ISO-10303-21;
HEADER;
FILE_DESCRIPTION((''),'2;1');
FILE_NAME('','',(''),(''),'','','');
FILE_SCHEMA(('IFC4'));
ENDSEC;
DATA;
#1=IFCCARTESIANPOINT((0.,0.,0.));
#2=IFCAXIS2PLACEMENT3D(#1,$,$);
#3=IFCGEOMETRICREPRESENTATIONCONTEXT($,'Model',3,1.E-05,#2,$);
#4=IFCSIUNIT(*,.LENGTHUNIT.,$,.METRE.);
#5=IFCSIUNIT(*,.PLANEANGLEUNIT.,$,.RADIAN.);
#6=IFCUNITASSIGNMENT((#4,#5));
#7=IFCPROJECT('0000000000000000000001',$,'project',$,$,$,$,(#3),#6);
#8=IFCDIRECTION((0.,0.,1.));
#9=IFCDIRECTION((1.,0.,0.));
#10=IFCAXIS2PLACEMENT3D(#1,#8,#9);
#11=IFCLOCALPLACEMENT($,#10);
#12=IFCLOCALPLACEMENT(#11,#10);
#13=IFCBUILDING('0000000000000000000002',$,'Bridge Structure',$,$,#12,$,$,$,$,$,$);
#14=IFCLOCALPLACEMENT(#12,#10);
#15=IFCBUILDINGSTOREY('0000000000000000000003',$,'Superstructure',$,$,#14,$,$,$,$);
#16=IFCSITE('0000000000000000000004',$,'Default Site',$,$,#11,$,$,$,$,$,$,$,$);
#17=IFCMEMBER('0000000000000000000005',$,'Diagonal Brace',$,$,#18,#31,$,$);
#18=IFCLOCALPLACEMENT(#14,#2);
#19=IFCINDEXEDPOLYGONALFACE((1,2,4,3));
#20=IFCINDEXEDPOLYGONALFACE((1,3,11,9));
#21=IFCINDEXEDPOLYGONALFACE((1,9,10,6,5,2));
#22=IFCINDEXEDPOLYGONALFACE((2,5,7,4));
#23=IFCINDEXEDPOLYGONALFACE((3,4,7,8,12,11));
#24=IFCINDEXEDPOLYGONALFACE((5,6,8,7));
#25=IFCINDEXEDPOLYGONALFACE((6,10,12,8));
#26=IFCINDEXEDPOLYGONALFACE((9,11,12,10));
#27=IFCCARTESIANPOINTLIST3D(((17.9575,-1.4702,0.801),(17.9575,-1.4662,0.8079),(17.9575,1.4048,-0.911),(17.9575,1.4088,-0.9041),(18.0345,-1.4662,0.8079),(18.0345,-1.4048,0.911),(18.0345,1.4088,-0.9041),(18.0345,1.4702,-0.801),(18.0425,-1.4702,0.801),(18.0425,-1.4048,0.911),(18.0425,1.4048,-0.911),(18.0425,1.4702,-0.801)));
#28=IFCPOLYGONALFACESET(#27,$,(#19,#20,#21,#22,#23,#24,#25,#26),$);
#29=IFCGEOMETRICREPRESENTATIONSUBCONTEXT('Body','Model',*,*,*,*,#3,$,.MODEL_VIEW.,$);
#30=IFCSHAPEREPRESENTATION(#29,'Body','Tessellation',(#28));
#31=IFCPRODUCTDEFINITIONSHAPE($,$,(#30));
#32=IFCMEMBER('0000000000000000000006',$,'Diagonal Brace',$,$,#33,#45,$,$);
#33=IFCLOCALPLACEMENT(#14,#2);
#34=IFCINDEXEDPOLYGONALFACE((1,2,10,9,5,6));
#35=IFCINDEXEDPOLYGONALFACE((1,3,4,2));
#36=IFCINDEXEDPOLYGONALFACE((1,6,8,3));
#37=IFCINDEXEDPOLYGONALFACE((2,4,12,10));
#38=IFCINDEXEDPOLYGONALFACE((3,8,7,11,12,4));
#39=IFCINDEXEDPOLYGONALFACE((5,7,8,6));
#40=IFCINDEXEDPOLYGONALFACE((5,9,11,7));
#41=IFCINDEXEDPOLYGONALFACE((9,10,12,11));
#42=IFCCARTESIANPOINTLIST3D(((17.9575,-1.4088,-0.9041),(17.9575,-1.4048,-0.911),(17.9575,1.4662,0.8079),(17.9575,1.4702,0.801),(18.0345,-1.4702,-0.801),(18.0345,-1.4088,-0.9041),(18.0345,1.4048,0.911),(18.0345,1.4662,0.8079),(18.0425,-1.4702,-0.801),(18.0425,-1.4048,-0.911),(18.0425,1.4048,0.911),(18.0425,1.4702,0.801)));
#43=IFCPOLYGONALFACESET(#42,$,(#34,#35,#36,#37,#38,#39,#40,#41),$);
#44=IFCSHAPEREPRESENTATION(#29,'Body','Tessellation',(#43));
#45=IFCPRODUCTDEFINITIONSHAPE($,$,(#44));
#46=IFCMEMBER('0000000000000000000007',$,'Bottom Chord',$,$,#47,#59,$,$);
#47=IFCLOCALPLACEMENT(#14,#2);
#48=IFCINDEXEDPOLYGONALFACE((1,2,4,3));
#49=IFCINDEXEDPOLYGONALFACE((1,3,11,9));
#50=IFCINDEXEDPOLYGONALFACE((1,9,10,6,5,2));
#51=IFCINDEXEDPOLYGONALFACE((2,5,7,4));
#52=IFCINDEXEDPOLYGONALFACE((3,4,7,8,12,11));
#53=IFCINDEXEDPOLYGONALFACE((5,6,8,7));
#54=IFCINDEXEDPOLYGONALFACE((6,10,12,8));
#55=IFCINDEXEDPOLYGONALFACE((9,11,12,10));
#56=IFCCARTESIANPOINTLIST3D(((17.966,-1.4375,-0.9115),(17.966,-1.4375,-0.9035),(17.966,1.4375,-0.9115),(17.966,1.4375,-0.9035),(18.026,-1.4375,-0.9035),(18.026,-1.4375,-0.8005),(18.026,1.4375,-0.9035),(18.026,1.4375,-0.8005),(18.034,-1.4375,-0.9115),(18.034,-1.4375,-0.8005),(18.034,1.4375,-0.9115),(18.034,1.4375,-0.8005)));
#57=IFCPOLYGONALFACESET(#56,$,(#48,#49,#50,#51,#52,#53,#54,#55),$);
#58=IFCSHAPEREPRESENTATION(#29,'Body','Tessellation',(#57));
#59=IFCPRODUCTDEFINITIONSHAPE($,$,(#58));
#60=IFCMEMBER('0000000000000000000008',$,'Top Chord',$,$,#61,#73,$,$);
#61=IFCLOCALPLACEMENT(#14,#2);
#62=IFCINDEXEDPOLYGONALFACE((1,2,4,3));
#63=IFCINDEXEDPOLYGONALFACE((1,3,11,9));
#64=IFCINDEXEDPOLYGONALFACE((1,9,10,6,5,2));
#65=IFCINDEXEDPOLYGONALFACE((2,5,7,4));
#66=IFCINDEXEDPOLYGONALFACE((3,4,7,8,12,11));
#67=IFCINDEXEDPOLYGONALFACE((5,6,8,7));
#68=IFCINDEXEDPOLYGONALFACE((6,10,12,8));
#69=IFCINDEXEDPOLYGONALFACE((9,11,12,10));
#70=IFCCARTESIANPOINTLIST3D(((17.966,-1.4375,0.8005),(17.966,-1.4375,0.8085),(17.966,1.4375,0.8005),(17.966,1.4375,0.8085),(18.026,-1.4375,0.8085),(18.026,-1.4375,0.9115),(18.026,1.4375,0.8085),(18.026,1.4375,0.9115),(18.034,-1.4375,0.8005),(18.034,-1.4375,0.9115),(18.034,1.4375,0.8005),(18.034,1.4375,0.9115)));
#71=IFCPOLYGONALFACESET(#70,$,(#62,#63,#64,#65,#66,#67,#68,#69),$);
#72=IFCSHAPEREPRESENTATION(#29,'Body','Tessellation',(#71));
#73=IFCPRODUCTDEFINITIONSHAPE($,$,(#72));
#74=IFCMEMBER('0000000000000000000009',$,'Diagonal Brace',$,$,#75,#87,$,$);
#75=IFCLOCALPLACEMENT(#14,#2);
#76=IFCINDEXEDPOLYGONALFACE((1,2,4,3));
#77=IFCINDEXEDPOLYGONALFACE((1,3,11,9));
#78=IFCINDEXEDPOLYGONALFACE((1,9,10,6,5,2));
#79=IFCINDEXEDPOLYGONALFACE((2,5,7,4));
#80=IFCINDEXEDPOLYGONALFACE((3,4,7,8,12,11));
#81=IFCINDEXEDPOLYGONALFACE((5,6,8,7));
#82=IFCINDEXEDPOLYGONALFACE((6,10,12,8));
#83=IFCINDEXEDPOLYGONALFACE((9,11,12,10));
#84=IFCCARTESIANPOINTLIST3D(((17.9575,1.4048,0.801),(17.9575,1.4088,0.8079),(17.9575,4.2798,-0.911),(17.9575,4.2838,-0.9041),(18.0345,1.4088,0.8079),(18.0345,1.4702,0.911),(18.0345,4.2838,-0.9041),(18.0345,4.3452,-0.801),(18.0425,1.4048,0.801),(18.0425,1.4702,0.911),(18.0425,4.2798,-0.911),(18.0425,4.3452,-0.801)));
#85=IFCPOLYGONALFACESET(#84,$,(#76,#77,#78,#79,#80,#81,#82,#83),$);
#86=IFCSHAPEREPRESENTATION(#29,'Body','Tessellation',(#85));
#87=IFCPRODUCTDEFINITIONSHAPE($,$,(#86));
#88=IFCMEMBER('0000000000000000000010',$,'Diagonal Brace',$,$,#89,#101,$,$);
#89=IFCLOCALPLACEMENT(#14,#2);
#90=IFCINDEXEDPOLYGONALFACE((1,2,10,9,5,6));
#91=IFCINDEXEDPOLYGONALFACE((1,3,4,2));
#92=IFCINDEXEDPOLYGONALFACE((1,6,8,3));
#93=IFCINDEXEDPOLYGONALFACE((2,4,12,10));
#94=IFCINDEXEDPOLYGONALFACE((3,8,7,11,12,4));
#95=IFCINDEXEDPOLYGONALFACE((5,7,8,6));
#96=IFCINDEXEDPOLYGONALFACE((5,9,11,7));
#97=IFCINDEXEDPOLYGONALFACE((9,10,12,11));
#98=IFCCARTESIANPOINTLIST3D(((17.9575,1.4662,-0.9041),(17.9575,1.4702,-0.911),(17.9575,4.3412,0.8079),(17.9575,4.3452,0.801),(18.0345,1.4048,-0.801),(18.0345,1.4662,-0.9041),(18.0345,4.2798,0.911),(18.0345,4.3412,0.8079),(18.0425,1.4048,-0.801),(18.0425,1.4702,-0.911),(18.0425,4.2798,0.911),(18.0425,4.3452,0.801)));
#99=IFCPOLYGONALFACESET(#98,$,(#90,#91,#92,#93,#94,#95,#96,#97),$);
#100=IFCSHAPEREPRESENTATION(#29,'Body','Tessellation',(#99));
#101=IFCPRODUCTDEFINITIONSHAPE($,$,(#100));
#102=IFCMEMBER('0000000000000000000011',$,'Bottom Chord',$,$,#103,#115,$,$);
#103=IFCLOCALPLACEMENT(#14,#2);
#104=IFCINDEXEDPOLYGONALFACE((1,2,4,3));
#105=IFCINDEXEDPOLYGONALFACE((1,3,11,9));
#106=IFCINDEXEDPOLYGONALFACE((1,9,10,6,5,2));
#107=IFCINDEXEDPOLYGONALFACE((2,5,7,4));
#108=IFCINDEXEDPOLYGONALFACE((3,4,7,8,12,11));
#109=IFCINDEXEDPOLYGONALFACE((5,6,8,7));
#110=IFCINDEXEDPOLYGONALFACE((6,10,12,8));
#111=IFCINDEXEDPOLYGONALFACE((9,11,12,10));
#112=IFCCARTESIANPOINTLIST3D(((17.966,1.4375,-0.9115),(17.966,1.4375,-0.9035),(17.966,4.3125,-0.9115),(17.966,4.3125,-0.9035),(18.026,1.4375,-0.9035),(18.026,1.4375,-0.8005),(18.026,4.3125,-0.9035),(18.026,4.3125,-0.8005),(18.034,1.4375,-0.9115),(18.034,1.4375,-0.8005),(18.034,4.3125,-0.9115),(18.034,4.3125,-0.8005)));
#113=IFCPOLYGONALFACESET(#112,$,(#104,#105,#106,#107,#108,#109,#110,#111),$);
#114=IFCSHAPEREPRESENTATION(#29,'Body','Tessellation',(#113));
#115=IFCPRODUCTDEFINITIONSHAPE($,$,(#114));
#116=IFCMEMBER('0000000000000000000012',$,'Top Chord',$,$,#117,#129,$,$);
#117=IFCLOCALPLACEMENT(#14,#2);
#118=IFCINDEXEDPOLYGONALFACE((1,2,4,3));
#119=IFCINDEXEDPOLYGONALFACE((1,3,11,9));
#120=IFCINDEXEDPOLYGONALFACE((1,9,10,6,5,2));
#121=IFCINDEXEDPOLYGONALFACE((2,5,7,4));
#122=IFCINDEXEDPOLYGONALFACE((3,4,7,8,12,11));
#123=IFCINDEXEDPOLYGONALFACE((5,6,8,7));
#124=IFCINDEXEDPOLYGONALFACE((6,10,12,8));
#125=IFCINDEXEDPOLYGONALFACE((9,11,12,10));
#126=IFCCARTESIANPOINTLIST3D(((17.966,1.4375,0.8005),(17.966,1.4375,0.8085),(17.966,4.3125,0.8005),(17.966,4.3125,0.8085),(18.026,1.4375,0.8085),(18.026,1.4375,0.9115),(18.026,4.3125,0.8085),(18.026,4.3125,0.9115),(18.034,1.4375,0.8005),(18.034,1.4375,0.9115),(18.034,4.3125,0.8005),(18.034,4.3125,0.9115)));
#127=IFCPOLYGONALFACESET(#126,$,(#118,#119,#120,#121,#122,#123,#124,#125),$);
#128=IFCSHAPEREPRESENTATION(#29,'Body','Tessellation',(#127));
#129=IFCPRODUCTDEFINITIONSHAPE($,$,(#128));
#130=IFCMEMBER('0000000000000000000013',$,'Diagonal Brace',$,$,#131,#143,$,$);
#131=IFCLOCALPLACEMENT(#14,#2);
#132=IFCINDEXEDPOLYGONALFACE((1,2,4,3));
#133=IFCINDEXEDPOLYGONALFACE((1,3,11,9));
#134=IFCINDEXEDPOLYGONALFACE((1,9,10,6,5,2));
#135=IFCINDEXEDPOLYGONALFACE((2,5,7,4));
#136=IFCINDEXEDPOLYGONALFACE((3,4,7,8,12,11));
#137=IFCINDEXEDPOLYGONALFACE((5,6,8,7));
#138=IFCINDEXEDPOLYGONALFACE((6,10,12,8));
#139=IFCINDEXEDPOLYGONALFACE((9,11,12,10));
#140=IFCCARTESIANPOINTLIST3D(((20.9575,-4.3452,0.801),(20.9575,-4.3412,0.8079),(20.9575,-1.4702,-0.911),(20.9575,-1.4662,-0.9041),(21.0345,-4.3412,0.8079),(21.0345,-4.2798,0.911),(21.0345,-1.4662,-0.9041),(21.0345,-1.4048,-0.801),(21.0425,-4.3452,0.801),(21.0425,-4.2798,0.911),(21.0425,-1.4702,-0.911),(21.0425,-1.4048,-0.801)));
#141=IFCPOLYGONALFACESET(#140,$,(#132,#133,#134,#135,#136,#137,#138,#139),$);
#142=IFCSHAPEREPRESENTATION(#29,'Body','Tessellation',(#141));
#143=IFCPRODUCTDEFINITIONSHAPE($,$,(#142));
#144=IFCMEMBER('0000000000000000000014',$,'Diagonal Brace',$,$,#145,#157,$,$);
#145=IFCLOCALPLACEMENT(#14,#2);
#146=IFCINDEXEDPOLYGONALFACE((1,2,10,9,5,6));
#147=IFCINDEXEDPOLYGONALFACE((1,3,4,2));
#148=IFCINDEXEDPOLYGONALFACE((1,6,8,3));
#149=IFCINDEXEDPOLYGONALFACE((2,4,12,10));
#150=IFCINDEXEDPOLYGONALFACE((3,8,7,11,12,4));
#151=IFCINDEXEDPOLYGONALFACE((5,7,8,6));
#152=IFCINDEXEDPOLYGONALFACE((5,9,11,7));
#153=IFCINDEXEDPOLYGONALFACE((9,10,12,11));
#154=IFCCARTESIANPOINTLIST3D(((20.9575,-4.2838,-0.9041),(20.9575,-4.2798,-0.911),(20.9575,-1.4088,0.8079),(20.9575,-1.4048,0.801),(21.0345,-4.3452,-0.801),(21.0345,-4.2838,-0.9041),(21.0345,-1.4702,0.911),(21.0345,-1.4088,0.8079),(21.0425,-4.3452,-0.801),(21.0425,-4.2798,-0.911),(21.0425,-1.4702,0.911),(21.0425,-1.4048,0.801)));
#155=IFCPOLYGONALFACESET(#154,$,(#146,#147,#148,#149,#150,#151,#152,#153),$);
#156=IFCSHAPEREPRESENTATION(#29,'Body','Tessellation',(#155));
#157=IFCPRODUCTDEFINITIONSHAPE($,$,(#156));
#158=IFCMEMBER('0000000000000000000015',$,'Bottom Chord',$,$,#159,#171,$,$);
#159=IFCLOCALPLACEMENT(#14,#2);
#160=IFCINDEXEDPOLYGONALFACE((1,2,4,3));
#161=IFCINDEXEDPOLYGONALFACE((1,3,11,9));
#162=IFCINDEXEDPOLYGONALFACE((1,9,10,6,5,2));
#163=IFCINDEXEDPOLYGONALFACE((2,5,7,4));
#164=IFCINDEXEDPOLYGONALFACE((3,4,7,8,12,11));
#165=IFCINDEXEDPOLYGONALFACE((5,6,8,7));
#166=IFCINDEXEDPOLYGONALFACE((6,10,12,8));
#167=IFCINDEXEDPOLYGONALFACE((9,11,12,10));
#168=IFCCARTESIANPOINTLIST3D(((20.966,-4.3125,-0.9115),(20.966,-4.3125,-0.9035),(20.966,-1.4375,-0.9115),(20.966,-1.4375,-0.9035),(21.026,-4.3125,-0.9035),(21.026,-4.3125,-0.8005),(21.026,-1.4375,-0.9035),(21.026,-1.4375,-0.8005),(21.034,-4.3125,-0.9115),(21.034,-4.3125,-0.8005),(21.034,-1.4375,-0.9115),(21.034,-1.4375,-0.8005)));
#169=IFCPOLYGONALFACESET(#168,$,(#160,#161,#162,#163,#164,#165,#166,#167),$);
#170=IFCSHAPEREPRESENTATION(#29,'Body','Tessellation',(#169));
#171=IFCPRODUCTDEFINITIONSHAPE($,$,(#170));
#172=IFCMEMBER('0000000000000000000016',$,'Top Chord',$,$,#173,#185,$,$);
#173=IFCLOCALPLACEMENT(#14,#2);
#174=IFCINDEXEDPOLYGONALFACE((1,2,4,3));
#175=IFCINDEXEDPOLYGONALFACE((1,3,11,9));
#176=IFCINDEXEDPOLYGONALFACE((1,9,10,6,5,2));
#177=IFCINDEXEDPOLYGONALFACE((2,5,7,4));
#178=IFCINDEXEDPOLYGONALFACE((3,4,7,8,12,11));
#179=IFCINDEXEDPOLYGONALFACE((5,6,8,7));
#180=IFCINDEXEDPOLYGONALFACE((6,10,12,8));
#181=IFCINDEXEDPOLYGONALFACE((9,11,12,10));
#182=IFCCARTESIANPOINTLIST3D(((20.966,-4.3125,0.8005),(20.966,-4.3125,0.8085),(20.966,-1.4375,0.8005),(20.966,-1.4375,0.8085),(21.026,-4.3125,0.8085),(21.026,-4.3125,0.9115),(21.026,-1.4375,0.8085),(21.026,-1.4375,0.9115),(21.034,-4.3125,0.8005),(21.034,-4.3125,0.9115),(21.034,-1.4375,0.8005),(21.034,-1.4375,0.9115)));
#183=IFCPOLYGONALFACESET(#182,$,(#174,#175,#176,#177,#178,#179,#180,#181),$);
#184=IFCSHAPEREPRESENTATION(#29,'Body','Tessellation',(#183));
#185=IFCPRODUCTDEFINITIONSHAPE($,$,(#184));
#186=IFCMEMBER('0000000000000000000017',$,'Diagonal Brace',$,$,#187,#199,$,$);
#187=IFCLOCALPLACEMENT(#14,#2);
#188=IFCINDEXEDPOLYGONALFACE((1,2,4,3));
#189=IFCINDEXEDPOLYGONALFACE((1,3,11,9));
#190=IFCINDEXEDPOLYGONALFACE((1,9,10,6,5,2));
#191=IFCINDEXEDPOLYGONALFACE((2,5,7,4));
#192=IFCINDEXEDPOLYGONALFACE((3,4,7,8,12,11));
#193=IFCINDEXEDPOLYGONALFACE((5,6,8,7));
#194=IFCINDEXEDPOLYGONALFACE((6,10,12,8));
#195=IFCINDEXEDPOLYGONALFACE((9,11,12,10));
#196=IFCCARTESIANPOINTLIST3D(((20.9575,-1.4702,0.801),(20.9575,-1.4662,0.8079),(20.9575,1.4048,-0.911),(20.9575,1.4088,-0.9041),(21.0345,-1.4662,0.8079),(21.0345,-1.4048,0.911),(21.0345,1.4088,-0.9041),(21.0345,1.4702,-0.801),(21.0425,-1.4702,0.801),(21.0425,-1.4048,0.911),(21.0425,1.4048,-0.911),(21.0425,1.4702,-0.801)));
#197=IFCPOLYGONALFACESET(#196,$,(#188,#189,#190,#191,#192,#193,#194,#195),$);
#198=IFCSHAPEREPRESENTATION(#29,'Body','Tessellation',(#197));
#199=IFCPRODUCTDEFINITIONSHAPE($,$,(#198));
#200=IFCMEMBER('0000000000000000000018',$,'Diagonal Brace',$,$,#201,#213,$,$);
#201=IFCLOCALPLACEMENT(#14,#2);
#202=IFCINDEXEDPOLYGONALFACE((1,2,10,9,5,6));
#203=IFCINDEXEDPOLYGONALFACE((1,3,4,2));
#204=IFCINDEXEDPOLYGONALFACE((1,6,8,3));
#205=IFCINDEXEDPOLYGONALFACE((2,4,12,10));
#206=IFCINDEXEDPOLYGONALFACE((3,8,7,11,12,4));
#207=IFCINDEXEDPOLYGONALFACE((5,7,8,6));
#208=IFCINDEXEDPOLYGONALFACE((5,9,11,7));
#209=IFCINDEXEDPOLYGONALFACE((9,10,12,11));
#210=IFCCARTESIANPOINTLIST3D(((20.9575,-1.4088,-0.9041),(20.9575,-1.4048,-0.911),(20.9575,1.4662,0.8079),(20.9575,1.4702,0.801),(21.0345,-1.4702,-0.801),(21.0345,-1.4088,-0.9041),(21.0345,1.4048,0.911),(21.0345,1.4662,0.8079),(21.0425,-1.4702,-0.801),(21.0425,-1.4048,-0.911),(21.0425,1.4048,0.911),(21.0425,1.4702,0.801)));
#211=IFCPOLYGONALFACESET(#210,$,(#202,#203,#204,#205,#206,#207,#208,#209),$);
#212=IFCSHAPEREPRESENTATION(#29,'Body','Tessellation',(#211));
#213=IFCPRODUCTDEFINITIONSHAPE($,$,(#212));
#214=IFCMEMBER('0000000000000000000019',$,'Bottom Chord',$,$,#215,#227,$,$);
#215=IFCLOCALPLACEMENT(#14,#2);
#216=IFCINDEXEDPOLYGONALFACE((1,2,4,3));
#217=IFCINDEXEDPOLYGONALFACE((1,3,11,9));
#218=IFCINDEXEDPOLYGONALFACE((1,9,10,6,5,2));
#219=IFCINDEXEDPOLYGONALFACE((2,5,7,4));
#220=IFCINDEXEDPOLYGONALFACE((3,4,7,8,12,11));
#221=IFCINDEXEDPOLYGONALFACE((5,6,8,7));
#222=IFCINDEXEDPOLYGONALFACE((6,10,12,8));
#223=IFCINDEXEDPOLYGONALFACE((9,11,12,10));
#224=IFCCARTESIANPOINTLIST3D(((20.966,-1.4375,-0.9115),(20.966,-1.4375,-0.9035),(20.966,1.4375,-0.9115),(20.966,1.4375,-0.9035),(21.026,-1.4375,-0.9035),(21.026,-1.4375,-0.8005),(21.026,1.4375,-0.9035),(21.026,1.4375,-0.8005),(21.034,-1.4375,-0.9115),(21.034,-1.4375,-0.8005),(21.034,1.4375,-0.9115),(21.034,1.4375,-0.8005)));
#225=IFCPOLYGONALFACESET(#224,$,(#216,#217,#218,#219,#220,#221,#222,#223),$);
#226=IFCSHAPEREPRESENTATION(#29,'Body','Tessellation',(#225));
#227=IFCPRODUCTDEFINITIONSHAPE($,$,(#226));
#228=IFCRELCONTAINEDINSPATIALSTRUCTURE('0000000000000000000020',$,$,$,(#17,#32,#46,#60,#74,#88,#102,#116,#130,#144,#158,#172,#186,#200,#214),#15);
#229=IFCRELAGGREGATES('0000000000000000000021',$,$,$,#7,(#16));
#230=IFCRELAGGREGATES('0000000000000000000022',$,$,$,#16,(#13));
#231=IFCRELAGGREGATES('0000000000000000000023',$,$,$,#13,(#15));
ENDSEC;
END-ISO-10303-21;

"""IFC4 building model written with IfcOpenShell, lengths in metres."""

from ifc_helpers import new_model, si_unit, frame, origin, origin_with_axes, origin_2d_with_axis, place, context, subcontext, project, spatial, l_section, extrude, element, save


model = new_model("IFC4")

# Units and contexts
model_context = context("Model", 3, precision=1e-05, world=origin())
body_context = subcontext(model_context, "Body", "Model", "MODEL_VIEW")
ifc_project = project(units=[si_unit("LENGTHUNIT", "METRE"), si_unit("PLANEANGLEUNIT", "RADIAN")], contexts=[model_context])

# Site, building, storey
site_placement = place(None, origin_with_axes())
site = spatial("IfcSite", under=ifc_project, at=site_placement, Name="Default Site")
building_placement = place(site_placement, origin_with_axes())
building = spatial("IfcBuilding", under=site, at=building_placement, Name="Bridge Structure")
storey_placement = place(building_placement, origin_with_axes())
storey = spatial("IfcBuildingStorey", under=building, at=storey_placement, Name="Superstructure")

# Members
for number, where, z_axis, x_axis, name in (
    (1, (18.0, -1.4375, 0.856), (0.0, 0.859202, -0.511636), (-1.0, 0.0, 0.0), "Diagonal Brace"),
    (2, (18.0, -1.4375, -0.856), (0.0, 0.859202, 0.511636), (-1.0, 0.0, 0.0), "Diagonal Brace"),
):
    element("IfcMember", number, at=place(storey_placement, frame(where, z_axis=z_axis, x_axis=x_axis)), inside=storey, Name=name, context=body_context, shape_type="SweptSolid", body=[
        extrude(l_section(Depth=0.128, Width=0.085, Thickness=0.008, at=origin_2d_with_axis()), origin_with_axes(), (0.0, 0.0, 1.0), 3.3461),
    ])
for number, where, z_axis, x_axis, name in (
    (3, (18.0, -1.4375, -0.856), (0.0, 1.0, 0.0), (-1.0, 0.0, 0.0), "Bottom Chord"),
    (4, (18.0, -1.4375, 0.856), (0.0, 1.0, 0.0), (-1.0, 0.0, 0.0), "Top Chord"),
):
    element("IfcMember", number, at=place(storey_placement, frame(where, z_axis=z_axis, x_axis=x_axis)), inside=storey, Name=name, context=body_context, shape_type="SweptSolid", body=[
        extrude(l_section(Depth=0.111, Width=0.068, Thickness=0.008, at=origin_2d_with_axis()), origin_with_axes(), (0.0, 0.0, 1.0), 2.875),
    ])
for number, where, z_axis, x_axis, name in (
    (5, (18.0, 1.4375, 0.856), (0.0, 0.859202, -0.511636), (-1.0, 0.0, 0.0), "Diagonal Brace"),
    (6, (18.0, 1.4375, -0.856), (0.0, 0.859202, 0.511636), (-1.0, 0.0, 0.0), "Diagonal Brace"),
):
    element("IfcMember", number, at=place(storey_placement, frame(where, z_axis=z_axis, x_axis=x_axis)), inside=storey, Name=name, context=body_context, shape_type="SweptSolid", body=[
        extrude(l_section(Depth=0.128, Width=0.085, Thickness=0.008, at=origin_2d_with_axis()), origin_with_axes(), (0.0, 0.0, 1.0), 3.3461),
    ])
for number, where, z_axis, x_axis, name in (
    (7, (18.0, 1.4375, -0.856), (0.0, 1.0, 0.0), (-1.0, 0.0, 0.0), "Bottom Chord"),
    (8, (18.0, 1.4375, 0.856), (0.0, 1.0, 0.0), (-1.0, 0.0, 0.0), "Top Chord"),
):
    element("IfcMember", number, at=place(storey_placement, frame(where, z_axis=z_axis, x_axis=x_axis)), inside=storey, Name=name, context=body_context, shape_type="SweptSolid", body=[
        extrude(l_section(Depth=0.111, Width=0.068, Thickness=0.008, at=origin_2d_with_axis()), origin_with_axes(), (0.0, 0.0, 1.0), 2.875),
    ])
for number, where, z_axis, x_axis, name in (
    (9, (21.0, -4.3125, 0.856), (0.0, 0.859202, -0.511636), (-1.0, 0.0, 0.0), "Diagonal Brace"),
    (10, (21.0, -4.3125, -0.856), (0.0, 0.859202, 0.511636), (-1.0, 0.0, 0.0), "Diagonal Brace"),
):
    element("IfcMember", number, at=place(storey_placement, frame(where, z_axis=z_axis, x_axis=x_axis)), inside=storey, Name=name, context=body_context, shape_type="SweptSolid", body=[
        extrude(l_section(Depth=0.128, Width=0.085, Thickness=0.008, at=origin_2d_with_axis()), origin_with_axes(), (0.0, 0.0, 1.0), 3.3461),
    ])
for number, where, z_axis, x_axis, name in (
    (11, (21.0, -4.3125, -0.856), (0.0, 1.0, 0.0), (-1.0, 0.0, 0.0), "Bottom Chord"),
    (12, (21.0, -4.3125, 0.856), (0.0, 1.0, 0.0), (-1.0, 0.0, 0.0), "Top Chord"),
):
    element("IfcMember", number, at=place(storey_placement, frame(where, z_axis=z_axis, x_axis=x_axis)), inside=storey, Name=name, context=body_context, shape_type="SweptSolid", body=[
        extrude(l_section(Depth=0.111, Width=0.068, Thickness=0.008, at=origin_2d_with_axis()), origin_with_axes(), (0.0, 0.0, 1.0), 2.875),
    ])
for number, where, z_axis, x_axis, name in (
    (13, (21.0, -1.4375, 0.856), (0.0, 0.859202, -0.511636), (-1.0, 0.0, 0.0), "Diagonal Brace"),
    (14, (21.0, -1.4375, -0.856), (0.0, 0.859202, 0.511636), (-1.0, 0.0, 0.0), "Diagonal Brace"),
):
    element("IfcMember", number, at=place(storey_placement, frame(where, z_axis=z_axis, x_axis=x_axis)), inside=storey, Name=name, context=body_context, shape_type="SweptSolid", body=[
        extrude(l_section(Depth=0.128, Width=0.085, Thickness=0.008, at=origin_2d_with_axis()), origin_with_axes(), (0.0, 0.0, 1.0), 3.3461),
    ])
for number, where, z_axis, x_axis, name in (
    (15, (21.0, -1.4375, -0.856), (0.0, 1.0, 0.0), (-1.0, 0.0, 0.0), "Bottom Chord"),
):
    element("IfcMember", number, at=place(storey_placement, frame(where, z_axis=z_axis, x_axis=x_axis)), inside=storey, Name=name, context=body_context, shape_type="SweptSolid", body=[
        extrude(l_section(Depth=0.111, Width=0.068, Thickness=0.008, at=origin_2d_with_axis()), origin_with_axes(), (0.0, 0.0, 1.0), 2.875),
    ])

save(model, "model.ifc")
